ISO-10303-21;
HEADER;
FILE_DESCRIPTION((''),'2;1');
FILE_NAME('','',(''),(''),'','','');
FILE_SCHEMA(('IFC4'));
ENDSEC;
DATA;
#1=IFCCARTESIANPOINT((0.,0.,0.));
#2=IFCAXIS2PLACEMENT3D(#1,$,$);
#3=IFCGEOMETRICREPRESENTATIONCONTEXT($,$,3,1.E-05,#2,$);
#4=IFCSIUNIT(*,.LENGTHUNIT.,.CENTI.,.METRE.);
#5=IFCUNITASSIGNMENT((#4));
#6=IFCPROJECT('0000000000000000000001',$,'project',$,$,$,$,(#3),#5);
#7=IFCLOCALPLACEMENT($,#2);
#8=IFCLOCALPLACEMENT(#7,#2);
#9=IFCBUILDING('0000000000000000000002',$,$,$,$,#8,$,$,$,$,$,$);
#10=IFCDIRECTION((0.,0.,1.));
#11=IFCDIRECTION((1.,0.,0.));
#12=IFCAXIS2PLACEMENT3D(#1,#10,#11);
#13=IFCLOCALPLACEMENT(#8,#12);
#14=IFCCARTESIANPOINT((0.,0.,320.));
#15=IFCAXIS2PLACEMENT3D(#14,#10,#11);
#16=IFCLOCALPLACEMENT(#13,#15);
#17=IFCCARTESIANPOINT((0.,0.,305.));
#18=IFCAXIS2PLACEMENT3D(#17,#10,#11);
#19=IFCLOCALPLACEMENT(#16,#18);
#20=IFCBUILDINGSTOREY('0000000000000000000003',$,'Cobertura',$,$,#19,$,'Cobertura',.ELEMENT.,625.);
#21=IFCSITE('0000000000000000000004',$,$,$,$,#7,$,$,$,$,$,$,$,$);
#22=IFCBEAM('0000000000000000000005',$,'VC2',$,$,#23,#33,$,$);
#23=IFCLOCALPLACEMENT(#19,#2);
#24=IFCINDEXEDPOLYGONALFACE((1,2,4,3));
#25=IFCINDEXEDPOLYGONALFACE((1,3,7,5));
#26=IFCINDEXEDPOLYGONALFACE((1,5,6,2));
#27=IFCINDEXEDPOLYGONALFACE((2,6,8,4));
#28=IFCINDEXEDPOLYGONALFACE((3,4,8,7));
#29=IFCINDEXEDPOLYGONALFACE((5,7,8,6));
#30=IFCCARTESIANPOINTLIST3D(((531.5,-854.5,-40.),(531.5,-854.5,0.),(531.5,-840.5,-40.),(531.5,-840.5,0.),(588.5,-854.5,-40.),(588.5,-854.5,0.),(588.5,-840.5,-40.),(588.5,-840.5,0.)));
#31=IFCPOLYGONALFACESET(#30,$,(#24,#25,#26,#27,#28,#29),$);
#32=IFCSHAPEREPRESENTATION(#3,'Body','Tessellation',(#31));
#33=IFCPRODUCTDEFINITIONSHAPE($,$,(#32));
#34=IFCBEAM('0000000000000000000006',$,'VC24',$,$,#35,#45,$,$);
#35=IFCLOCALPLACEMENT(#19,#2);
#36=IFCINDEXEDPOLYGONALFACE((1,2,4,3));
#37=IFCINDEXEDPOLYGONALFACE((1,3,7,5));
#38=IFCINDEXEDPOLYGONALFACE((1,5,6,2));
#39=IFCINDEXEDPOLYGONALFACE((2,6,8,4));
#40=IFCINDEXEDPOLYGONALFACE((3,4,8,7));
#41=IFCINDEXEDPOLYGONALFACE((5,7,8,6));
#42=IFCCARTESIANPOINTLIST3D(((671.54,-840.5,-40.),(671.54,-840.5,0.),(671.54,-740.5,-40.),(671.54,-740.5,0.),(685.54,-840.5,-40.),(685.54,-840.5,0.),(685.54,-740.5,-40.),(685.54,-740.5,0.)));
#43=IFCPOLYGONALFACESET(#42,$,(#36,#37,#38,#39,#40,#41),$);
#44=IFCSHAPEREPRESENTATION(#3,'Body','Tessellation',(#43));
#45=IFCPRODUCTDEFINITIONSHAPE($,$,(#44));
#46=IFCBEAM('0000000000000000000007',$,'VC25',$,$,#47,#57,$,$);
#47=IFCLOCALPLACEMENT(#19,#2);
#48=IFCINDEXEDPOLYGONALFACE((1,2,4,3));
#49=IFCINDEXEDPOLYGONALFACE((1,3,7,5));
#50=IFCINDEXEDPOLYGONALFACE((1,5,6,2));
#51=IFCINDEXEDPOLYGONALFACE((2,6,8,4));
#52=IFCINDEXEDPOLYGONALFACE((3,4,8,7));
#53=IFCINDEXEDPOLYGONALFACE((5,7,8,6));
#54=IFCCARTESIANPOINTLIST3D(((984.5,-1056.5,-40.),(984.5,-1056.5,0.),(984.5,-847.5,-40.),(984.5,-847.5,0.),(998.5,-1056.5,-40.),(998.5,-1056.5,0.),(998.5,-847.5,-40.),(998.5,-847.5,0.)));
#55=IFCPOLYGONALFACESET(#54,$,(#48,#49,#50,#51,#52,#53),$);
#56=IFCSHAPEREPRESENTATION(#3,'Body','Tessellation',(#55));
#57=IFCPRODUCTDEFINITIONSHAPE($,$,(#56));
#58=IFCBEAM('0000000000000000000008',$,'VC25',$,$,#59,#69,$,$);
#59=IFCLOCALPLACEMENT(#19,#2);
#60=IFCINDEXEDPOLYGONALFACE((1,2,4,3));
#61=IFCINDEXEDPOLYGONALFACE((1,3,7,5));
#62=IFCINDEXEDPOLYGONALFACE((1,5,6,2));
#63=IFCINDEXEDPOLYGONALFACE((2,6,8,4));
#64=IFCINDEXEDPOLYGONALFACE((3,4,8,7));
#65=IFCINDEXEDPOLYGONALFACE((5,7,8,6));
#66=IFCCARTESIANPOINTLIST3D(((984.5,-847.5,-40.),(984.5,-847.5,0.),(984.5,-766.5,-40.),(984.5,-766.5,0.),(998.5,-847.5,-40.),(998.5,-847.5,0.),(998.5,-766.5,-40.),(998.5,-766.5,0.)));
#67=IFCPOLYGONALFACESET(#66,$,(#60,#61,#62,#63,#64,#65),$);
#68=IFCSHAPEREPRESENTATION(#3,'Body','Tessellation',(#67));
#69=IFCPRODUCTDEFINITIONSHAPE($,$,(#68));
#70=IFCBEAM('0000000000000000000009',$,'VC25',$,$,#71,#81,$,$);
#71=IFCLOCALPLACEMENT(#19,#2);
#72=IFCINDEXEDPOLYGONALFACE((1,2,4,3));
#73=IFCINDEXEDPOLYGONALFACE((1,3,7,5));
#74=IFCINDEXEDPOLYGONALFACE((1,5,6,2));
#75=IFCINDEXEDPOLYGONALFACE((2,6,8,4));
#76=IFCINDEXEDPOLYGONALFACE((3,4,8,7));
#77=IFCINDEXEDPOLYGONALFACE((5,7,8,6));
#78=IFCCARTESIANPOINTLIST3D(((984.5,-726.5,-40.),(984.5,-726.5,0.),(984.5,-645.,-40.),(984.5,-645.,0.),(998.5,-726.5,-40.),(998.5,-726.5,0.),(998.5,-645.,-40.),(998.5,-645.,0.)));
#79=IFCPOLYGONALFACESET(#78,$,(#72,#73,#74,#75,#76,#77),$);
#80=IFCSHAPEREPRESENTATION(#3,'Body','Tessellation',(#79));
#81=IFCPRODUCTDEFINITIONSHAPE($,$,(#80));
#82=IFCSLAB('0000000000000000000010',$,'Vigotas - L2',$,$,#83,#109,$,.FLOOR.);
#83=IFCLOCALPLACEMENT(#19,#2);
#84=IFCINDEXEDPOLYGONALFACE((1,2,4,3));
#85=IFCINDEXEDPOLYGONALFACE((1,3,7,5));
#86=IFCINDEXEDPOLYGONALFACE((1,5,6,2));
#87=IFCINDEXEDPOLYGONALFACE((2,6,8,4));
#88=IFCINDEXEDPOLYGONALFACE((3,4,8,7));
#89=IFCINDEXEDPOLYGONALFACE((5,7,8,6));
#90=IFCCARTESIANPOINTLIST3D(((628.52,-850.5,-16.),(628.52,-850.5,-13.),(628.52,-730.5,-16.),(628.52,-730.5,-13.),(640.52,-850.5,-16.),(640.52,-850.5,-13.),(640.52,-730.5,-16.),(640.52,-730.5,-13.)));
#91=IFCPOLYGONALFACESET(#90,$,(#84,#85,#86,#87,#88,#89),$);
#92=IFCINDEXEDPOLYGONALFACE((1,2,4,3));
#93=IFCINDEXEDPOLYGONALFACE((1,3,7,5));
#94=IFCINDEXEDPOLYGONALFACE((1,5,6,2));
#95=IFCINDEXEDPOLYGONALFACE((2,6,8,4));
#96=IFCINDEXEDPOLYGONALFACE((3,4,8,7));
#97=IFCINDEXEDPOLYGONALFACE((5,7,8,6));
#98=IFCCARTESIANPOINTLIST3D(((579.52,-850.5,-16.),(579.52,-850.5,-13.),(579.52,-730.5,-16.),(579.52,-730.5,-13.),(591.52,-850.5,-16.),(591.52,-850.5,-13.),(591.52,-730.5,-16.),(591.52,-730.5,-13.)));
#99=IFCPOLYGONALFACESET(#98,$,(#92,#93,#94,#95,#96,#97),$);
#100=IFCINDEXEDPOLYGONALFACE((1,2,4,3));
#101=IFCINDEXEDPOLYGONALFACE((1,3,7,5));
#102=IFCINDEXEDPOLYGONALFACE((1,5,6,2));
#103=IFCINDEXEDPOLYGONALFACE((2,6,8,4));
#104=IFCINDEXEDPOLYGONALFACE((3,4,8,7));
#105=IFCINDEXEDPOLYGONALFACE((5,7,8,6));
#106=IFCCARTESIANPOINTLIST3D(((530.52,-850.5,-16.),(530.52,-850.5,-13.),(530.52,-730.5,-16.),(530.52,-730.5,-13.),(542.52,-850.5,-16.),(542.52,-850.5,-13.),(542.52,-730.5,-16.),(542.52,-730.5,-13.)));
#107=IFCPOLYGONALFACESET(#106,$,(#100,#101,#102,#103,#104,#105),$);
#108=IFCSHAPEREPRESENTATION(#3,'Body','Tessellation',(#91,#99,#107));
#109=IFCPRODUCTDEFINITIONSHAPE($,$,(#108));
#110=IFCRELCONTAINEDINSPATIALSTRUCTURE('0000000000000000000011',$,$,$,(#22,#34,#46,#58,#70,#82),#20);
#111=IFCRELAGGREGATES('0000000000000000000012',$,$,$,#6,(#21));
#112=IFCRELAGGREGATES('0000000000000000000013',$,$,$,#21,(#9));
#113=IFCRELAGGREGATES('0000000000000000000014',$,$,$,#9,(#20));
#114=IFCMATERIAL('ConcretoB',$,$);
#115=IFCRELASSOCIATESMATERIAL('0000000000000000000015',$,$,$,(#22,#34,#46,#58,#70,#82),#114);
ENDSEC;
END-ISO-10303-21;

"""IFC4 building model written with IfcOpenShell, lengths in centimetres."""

from ifc_helpers import new_model, si_unit, frame, origin, origin_with_axes, place, context, project, spatial, polyline, outline, extrude, material, element, save


model = new_model("IFC4")

# Units and contexts
context_of_model = context(None, 3, precision=1e-05, world=origin())
ifc_project = project(units=[si_unit("LENGTHUNIT", "METRE", prefix="CENTI")], contexts=[context_of_model])

# Site, building, storey
site_placement = place(None, origin())
site = spatial("IfcSite", under=ifc_project, at=site_placement)
building_placement = place(site_placement, origin())
building = spatial("IfcBuilding", under=site, at=building_placement)
placement_1 = place(building_placement, origin_with_axes())
placement_2 = place(placement_1, frame((0.0, 0.0, 320.0), z_axis=(0.0, 0.0, 1.0), x_axis=(1.0, 0.0, 0.0)))
storey_placement = place(placement_2, frame((0.0, 0.0, 305.0), z_axis=(0.0, 0.0, 1.0), x_axis=(1.0, 0.0, 0.0)))
storey = spatial("IfcBuildingStorey", under=building, at=storey_placement, Name="Cobertura", LongName="Cobertura", CompositionType="ELEMENT", Elevation=625.0)

# Shared definitions
ifc_material_1 = material(Name="ConcretoB")

# Beams
beam_1_placement = place(storey_placement, frame((560.0, -847.5, 0.0), z_axis=(0.0, 0.0, 1.0), x_axis=(1.0, 0.0, 0.0)))
element("IfcBeam", 1, at=beam_1_placement, inside=storey, material=ifc_material_1, Name="VC2", context=context_of_model, shape_type="SolidModel", body=[
    extrude(outline(polyline([(-7.0, -20.0), (7.0, -20.0), (7.0, 20.0), (-7.0, 20.0), (-7.0, -20.0)])), frame((-28.5, 0.0, -20.0), z_axis=(1.0, 0.0, 0.0), x_axis=(0.0, -1.0, 0.0)), (0.0, 0.0, 1.0), 57.0),
])
beam_2_placement = place(storey_placement, frame((678.54, -790.5, 0.0), z_axis=(0.0, 0.0, 1.0), x_axis=(1.0, 0.0, 0.0)))
element("IfcBeam", 2, at=beam_2_placement, inside=storey, material=ifc_material_1, Name="VC24", context=context_of_model, shape_type="SolidModel", body=[
    extrude(outline(polyline([(-7.0, -20.0), (7.0, -20.0), (7.0, 20.0), (-7.0, 20.0), (-7.0, -20.0)])), frame((0.0, -50.0, -20.0), z_axis=(0.0, 1.0, 0.0), x_axis=(1.0, 0.0, 0.0)), (0.0, 0.0, 1.0), 100.0),
])
beam_3_placement = place(storey_placement, frame((991.5, -952.0, 0.0), z_axis=(0.0, 0.0, 1.0), x_axis=(1.0, 0.0, 0.0)))
element("IfcBeam", 3, at=beam_3_placement, inside=storey, material=ifc_material_1, Name="VC25", context=context_of_model, shape_type="SolidModel", body=[
    extrude(outline(polyline([(-7.0, -20.0), (7.0, -20.0), (7.0, 20.0), (-7.0, 20.0), (-7.0, -20.0)])), frame((0.0, -104.5, -20.0), z_axis=(0.0, 1.0, 0.0), x_axis=(1.0, 0.0, 0.0)), (0.0, 0.0, 1.0), 209.0),
])
beam_4_placement = place(storey_placement, frame((991.5, -807.0, 0.0), z_axis=(0.0, 0.0, 1.0), x_axis=(1.0, 0.0, 0.0)))
element("IfcBeam", 4, at=beam_4_placement, inside=storey, material=ifc_material_1, Name="VC25", context=context_of_model, shape_type="SolidModel", body=[
    extrude(outline(polyline([(-7.0, -20.0), (7.0, -20.0), (7.0, 20.0), (-7.0, 20.0), (-7.0, -20.0)])), frame((0.0, -40.5, -20.0), z_axis=(0.0, 1.0, 0.0), x_axis=(1.0, 0.0, 0.0)), (0.0, 0.0, 1.0), 81.0),
])
beam_5_placement = place(storey_placement, frame((991.5, -685.75, 0.0), z_axis=(0.0, 0.0, 1.0), x_axis=(1.0, 0.0, 0.0)))
element("IfcBeam", 5, at=beam_5_placement, inside=storey, material=ifc_material_1, Name="VC25", context=context_of_model, shape_type="SolidModel", body=[
    extrude(outline(polyline([(-7.0, -20.0), (7.0, -20.0), (7.0, 20.0), (-7.0, 20.0), (-7.0, -20.0)])), frame((0.0, -40.75, -20.0), z_axis=(0.0, 1.0, 0.0), x_axis=(1.0, 0.0, 0.0)), (0.0, 0.0, 1.0), 81.5),
])

# Slab
slab_placement = place(storey_placement, frame((585.52, -790.5, -13.0), z_axis=(0.0, 0.0, 1.0), x_axis=(1.0, 0.0, 0.0)))
element("IfcSlab", 6, at=slab_placement, inside=storey, material=ifc_material_1, Name="Vigotas - L2", PredefinedType="FLOOR", context=context_of_model, shape_type="SolidModel", body=[
    extrude(outline(polyline([(6.0, 1.5), (-6.0, 1.5), (-6.0, -1.5), (6.0, -1.5), (6.0, 1.5), (6.0, 1.5)])), frame((49.0, -60.0, -1.5), z_axis=(0.0, 1.0, 0.0), x_axis=(1.0, 0.0, 0.0)), (0.0, 0.0, 1.0), 120.0),
    extrude(outline(polyline([(6.0, 1.5), (-6.0, 1.5), (-6.0, -1.5), (6.0, -1.5), (6.0, 1.5), (6.0, 1.5)])), frame((0.0, -60.0, -1.5), z_axis=(0.0, 1.0, 0.0), x_axis=(1.0, 0.0, 0.0)), (0.0, 0.0, 1.0), 120.0),
    extrude(outline(polyline([(6.0, 1.5), (-6.0, 1.5), (-6.0, -1.5), (6.0, -1.5), (6.0, 1.5), (6.0, 1.5)])), frame((-49.0, -60.0, -1.5), z_axis=(0.0, 1.0, 0.0), x_axis=(1.0, 0.0, 0.0)), (0.0, 0.0, 1.0), 120.0),
])

save(model, "model.ifc")
